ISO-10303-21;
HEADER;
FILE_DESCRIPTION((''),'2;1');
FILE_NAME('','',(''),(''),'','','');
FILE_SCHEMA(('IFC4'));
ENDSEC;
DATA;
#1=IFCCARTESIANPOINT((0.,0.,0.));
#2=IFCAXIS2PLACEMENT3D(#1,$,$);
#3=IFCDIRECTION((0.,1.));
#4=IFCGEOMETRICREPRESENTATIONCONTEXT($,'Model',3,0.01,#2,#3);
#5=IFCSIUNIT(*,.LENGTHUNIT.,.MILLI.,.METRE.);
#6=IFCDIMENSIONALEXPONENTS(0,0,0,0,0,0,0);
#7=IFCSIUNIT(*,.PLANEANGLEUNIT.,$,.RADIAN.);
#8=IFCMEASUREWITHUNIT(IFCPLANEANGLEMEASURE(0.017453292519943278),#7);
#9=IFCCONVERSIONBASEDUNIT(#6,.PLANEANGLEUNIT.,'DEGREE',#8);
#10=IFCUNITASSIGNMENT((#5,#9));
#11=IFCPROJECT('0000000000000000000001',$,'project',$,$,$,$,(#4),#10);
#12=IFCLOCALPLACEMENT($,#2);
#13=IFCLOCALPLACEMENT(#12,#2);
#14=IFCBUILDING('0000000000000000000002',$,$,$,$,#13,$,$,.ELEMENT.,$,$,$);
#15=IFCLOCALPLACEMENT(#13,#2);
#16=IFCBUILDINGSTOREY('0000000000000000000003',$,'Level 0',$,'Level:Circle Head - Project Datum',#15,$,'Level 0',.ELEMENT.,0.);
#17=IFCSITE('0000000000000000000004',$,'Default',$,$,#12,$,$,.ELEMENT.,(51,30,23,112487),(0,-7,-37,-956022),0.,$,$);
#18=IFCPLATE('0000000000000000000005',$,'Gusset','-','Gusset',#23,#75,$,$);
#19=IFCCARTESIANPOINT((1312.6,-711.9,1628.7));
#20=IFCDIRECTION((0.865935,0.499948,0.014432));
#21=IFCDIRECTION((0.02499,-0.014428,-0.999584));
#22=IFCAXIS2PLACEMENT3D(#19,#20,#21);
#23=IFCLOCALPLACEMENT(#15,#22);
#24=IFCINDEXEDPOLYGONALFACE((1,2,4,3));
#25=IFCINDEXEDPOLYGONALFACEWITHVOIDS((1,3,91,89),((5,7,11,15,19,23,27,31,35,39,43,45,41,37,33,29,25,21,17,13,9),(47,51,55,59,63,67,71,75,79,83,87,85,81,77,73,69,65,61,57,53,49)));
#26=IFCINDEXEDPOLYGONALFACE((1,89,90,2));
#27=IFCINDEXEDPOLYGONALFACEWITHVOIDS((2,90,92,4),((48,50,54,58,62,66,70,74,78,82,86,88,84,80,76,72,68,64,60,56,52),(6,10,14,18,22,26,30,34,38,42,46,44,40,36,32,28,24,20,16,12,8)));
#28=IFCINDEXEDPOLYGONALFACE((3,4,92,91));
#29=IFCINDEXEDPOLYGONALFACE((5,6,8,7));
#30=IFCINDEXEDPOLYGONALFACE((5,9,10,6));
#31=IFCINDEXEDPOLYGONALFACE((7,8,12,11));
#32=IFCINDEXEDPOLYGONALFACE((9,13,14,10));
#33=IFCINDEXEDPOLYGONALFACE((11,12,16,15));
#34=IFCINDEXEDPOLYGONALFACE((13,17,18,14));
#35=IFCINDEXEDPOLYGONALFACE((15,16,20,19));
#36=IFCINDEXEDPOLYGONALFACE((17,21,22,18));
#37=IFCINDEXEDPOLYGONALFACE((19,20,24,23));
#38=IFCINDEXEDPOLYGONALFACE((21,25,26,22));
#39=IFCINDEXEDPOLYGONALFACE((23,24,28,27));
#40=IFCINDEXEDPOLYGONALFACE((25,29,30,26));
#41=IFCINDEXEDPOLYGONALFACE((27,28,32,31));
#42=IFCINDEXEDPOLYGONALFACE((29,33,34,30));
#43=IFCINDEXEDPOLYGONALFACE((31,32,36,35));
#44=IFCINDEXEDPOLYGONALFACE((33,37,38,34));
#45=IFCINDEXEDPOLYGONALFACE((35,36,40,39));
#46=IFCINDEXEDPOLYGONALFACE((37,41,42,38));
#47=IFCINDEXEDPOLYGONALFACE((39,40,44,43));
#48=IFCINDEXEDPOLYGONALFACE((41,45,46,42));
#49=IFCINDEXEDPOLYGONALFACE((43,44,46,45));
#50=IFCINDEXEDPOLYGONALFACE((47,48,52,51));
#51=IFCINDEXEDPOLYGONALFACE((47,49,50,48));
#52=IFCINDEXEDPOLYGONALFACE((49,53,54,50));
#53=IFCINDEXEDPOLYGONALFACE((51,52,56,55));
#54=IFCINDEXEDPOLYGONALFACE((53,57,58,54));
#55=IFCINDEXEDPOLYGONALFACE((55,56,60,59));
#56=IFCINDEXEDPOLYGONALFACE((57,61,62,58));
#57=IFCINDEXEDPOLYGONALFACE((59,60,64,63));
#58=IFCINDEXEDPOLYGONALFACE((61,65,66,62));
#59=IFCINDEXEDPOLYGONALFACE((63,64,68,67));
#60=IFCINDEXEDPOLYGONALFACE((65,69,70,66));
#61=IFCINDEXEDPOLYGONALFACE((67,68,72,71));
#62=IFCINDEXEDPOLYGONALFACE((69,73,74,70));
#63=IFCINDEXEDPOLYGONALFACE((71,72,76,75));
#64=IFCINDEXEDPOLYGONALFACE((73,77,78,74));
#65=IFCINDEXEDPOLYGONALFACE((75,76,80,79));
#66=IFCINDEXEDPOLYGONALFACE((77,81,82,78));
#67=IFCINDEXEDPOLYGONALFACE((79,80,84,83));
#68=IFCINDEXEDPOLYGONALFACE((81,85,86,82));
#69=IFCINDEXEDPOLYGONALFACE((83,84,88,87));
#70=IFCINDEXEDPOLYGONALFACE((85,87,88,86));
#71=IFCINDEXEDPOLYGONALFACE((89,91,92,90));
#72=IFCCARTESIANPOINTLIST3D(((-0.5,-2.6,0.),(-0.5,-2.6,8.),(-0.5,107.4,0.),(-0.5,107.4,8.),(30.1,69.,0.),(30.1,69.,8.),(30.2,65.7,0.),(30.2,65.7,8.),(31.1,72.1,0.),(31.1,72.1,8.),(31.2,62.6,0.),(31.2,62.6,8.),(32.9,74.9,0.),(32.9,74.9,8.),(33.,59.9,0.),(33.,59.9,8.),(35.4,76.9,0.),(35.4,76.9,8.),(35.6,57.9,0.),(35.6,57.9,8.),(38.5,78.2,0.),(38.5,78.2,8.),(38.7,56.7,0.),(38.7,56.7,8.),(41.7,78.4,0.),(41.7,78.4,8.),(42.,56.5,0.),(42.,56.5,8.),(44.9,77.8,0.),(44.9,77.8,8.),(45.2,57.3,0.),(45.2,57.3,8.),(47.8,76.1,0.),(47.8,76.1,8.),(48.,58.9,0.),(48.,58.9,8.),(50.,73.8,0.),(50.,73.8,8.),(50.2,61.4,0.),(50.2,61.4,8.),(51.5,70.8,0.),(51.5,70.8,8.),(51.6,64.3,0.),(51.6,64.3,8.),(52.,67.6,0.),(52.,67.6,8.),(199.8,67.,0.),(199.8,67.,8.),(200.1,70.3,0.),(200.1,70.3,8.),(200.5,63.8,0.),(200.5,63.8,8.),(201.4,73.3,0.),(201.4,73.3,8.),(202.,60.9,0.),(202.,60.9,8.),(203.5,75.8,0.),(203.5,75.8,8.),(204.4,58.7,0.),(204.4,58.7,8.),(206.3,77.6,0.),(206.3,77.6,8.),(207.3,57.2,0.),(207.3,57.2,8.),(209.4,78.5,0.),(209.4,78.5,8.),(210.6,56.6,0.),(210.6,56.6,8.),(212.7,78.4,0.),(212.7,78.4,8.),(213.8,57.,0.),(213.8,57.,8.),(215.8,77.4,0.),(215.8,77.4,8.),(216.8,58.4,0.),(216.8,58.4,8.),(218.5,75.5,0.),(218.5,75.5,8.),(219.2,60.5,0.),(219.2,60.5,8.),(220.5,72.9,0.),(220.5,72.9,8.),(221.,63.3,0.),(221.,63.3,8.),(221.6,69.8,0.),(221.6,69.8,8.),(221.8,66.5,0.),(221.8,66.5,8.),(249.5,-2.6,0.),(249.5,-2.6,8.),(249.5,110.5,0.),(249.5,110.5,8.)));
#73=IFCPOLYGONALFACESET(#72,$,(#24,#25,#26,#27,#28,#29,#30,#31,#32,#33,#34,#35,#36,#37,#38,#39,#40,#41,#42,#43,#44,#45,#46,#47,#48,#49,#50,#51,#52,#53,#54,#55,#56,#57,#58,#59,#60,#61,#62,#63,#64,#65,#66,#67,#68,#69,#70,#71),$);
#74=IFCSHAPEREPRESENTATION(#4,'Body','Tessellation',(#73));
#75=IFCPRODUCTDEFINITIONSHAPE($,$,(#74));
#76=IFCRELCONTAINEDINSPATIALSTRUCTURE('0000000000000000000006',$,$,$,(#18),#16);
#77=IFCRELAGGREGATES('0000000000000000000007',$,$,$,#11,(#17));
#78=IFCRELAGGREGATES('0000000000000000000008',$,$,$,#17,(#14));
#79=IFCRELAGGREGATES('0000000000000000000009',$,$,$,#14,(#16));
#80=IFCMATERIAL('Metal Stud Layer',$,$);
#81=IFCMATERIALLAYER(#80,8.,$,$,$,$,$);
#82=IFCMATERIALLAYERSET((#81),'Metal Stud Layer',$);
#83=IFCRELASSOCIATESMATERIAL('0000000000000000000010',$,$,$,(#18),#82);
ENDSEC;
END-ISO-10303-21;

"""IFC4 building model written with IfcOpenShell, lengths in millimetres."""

from ifc_helpers import new_model, entity, si_unit, converted_unit, direction, frame, origin, origin_with_axes, origin_2d_with_axis, place, context, project, spatial, polyline, circle, outline, extrude, material, layer, layer_set, element, save


model = new_model("IFC4")

# Units and contexts
model_context = context("Model", 3, precision=0.01, world=origin(), true_north=direction((0.0, 1.0)))
ifc_project = project(units=[si_unit("LENGTHUNIT", "METRE", prefix="MILLI"), converted_unit("PLANEANGLEUNIT", "DEGREE", entity("IfcPlaneAngleMeasure", 0.017453292519943278), si_unit("PLANEANGLEUNIT", "RADIAN"), dimensions=[0, 0, 0, 0, 0, 0, 0])], contexts=[model_context])

# Site, building, storey
site_placement = place(None, origin())
site = spatial("IfcSite", under=ifc_project, at=site_placement, Name="Default", CompositionType="ELEMENT", RefLatitude=(51, 30, 23, 112487), RefLongitude=(0, -7, -37, -956022), RefElevation=0.0)
building_placement = place(site_placement, origin())
building = spatial("IfcBuilding", under=site, at=building_placement, CompositionType="ELEMENT")
storey_placement = place(building_placement, origin())
storey = spatial("IfcBuildingStorey", under=building, at=storey_placement, Name="Level 0", ObjectType="Level:Circle Head - Project Datum", LongName="Level 0", CompositionType="ELEMENT", Elevation=0.0)

# Plate, openings
ifc_material = material(Name="Metal Stud Layer")
ifc_layer_1 = layer(ifc_material, 8.0)
ifc_layer_set_1 = layer_set([ifc_layer_1], Name="Metal Stud Layer")
plate_1_placement = place(storey_placement, frame((1312.6, -711.9, 1628.7), z_axis=(0.865935, 0.499948, 0.014432), x_axis=(0.02499, -0.014428, -0.999584)))
plate_1 = element("IfcPlate", 1, at=plate_1_placement, inside=storey, material=ifc_layer_set_1, Name="Gusset", Description="-", ObjectType="Gusset", context=model_context, shape_type="SweptSolid", body=[
    extrude(outline(polyline([(-0.5, -2.6), (249.5, -2.6), (249.5, 110.5), (-0.5, 107.4), (-0.5, -2.6)])), origin_with_axes(), (0.0, 0.0, 1.0), 8.0),
])
opening_1_placement = place(plate_1_placement, frame((41.0, 67.5, 8.5), z_axis=(0.0, 0.0, -1.0), x_axis=(-0.509338, 0.860567, 0.0)))
element("IfcOpeningElement", 2, at=opening_1_placement, cuts=plate_1, ObjectType="Opening", context=model_context, shape_type="SweptSolid", body=[
    extrude(circle(Radius=11.0, at=origin_2d_with_axis()), origin(), (0.0, 0.0, 1.0), 9.0),
])
opening_2_placement = place(plate_1_placement, frame((210.8, 67.6, 8.5), z_axis=(0.0, 0.0, -1.0), x_axis=(0.454822, 0.890582, 0.0)))
element("IfcOpeningElement", 3, at=opening_2_placement, cuts=plate_1, ObjectType="Opening", context=model_context, shape_type="SweptSolid", body=[
    extrude(circle(Radius=11.0, at=origin_2d_with_axis()), origin(), (0.0, 0.0, 1.0), 9.0),
])

save(model, "model.ifc")
